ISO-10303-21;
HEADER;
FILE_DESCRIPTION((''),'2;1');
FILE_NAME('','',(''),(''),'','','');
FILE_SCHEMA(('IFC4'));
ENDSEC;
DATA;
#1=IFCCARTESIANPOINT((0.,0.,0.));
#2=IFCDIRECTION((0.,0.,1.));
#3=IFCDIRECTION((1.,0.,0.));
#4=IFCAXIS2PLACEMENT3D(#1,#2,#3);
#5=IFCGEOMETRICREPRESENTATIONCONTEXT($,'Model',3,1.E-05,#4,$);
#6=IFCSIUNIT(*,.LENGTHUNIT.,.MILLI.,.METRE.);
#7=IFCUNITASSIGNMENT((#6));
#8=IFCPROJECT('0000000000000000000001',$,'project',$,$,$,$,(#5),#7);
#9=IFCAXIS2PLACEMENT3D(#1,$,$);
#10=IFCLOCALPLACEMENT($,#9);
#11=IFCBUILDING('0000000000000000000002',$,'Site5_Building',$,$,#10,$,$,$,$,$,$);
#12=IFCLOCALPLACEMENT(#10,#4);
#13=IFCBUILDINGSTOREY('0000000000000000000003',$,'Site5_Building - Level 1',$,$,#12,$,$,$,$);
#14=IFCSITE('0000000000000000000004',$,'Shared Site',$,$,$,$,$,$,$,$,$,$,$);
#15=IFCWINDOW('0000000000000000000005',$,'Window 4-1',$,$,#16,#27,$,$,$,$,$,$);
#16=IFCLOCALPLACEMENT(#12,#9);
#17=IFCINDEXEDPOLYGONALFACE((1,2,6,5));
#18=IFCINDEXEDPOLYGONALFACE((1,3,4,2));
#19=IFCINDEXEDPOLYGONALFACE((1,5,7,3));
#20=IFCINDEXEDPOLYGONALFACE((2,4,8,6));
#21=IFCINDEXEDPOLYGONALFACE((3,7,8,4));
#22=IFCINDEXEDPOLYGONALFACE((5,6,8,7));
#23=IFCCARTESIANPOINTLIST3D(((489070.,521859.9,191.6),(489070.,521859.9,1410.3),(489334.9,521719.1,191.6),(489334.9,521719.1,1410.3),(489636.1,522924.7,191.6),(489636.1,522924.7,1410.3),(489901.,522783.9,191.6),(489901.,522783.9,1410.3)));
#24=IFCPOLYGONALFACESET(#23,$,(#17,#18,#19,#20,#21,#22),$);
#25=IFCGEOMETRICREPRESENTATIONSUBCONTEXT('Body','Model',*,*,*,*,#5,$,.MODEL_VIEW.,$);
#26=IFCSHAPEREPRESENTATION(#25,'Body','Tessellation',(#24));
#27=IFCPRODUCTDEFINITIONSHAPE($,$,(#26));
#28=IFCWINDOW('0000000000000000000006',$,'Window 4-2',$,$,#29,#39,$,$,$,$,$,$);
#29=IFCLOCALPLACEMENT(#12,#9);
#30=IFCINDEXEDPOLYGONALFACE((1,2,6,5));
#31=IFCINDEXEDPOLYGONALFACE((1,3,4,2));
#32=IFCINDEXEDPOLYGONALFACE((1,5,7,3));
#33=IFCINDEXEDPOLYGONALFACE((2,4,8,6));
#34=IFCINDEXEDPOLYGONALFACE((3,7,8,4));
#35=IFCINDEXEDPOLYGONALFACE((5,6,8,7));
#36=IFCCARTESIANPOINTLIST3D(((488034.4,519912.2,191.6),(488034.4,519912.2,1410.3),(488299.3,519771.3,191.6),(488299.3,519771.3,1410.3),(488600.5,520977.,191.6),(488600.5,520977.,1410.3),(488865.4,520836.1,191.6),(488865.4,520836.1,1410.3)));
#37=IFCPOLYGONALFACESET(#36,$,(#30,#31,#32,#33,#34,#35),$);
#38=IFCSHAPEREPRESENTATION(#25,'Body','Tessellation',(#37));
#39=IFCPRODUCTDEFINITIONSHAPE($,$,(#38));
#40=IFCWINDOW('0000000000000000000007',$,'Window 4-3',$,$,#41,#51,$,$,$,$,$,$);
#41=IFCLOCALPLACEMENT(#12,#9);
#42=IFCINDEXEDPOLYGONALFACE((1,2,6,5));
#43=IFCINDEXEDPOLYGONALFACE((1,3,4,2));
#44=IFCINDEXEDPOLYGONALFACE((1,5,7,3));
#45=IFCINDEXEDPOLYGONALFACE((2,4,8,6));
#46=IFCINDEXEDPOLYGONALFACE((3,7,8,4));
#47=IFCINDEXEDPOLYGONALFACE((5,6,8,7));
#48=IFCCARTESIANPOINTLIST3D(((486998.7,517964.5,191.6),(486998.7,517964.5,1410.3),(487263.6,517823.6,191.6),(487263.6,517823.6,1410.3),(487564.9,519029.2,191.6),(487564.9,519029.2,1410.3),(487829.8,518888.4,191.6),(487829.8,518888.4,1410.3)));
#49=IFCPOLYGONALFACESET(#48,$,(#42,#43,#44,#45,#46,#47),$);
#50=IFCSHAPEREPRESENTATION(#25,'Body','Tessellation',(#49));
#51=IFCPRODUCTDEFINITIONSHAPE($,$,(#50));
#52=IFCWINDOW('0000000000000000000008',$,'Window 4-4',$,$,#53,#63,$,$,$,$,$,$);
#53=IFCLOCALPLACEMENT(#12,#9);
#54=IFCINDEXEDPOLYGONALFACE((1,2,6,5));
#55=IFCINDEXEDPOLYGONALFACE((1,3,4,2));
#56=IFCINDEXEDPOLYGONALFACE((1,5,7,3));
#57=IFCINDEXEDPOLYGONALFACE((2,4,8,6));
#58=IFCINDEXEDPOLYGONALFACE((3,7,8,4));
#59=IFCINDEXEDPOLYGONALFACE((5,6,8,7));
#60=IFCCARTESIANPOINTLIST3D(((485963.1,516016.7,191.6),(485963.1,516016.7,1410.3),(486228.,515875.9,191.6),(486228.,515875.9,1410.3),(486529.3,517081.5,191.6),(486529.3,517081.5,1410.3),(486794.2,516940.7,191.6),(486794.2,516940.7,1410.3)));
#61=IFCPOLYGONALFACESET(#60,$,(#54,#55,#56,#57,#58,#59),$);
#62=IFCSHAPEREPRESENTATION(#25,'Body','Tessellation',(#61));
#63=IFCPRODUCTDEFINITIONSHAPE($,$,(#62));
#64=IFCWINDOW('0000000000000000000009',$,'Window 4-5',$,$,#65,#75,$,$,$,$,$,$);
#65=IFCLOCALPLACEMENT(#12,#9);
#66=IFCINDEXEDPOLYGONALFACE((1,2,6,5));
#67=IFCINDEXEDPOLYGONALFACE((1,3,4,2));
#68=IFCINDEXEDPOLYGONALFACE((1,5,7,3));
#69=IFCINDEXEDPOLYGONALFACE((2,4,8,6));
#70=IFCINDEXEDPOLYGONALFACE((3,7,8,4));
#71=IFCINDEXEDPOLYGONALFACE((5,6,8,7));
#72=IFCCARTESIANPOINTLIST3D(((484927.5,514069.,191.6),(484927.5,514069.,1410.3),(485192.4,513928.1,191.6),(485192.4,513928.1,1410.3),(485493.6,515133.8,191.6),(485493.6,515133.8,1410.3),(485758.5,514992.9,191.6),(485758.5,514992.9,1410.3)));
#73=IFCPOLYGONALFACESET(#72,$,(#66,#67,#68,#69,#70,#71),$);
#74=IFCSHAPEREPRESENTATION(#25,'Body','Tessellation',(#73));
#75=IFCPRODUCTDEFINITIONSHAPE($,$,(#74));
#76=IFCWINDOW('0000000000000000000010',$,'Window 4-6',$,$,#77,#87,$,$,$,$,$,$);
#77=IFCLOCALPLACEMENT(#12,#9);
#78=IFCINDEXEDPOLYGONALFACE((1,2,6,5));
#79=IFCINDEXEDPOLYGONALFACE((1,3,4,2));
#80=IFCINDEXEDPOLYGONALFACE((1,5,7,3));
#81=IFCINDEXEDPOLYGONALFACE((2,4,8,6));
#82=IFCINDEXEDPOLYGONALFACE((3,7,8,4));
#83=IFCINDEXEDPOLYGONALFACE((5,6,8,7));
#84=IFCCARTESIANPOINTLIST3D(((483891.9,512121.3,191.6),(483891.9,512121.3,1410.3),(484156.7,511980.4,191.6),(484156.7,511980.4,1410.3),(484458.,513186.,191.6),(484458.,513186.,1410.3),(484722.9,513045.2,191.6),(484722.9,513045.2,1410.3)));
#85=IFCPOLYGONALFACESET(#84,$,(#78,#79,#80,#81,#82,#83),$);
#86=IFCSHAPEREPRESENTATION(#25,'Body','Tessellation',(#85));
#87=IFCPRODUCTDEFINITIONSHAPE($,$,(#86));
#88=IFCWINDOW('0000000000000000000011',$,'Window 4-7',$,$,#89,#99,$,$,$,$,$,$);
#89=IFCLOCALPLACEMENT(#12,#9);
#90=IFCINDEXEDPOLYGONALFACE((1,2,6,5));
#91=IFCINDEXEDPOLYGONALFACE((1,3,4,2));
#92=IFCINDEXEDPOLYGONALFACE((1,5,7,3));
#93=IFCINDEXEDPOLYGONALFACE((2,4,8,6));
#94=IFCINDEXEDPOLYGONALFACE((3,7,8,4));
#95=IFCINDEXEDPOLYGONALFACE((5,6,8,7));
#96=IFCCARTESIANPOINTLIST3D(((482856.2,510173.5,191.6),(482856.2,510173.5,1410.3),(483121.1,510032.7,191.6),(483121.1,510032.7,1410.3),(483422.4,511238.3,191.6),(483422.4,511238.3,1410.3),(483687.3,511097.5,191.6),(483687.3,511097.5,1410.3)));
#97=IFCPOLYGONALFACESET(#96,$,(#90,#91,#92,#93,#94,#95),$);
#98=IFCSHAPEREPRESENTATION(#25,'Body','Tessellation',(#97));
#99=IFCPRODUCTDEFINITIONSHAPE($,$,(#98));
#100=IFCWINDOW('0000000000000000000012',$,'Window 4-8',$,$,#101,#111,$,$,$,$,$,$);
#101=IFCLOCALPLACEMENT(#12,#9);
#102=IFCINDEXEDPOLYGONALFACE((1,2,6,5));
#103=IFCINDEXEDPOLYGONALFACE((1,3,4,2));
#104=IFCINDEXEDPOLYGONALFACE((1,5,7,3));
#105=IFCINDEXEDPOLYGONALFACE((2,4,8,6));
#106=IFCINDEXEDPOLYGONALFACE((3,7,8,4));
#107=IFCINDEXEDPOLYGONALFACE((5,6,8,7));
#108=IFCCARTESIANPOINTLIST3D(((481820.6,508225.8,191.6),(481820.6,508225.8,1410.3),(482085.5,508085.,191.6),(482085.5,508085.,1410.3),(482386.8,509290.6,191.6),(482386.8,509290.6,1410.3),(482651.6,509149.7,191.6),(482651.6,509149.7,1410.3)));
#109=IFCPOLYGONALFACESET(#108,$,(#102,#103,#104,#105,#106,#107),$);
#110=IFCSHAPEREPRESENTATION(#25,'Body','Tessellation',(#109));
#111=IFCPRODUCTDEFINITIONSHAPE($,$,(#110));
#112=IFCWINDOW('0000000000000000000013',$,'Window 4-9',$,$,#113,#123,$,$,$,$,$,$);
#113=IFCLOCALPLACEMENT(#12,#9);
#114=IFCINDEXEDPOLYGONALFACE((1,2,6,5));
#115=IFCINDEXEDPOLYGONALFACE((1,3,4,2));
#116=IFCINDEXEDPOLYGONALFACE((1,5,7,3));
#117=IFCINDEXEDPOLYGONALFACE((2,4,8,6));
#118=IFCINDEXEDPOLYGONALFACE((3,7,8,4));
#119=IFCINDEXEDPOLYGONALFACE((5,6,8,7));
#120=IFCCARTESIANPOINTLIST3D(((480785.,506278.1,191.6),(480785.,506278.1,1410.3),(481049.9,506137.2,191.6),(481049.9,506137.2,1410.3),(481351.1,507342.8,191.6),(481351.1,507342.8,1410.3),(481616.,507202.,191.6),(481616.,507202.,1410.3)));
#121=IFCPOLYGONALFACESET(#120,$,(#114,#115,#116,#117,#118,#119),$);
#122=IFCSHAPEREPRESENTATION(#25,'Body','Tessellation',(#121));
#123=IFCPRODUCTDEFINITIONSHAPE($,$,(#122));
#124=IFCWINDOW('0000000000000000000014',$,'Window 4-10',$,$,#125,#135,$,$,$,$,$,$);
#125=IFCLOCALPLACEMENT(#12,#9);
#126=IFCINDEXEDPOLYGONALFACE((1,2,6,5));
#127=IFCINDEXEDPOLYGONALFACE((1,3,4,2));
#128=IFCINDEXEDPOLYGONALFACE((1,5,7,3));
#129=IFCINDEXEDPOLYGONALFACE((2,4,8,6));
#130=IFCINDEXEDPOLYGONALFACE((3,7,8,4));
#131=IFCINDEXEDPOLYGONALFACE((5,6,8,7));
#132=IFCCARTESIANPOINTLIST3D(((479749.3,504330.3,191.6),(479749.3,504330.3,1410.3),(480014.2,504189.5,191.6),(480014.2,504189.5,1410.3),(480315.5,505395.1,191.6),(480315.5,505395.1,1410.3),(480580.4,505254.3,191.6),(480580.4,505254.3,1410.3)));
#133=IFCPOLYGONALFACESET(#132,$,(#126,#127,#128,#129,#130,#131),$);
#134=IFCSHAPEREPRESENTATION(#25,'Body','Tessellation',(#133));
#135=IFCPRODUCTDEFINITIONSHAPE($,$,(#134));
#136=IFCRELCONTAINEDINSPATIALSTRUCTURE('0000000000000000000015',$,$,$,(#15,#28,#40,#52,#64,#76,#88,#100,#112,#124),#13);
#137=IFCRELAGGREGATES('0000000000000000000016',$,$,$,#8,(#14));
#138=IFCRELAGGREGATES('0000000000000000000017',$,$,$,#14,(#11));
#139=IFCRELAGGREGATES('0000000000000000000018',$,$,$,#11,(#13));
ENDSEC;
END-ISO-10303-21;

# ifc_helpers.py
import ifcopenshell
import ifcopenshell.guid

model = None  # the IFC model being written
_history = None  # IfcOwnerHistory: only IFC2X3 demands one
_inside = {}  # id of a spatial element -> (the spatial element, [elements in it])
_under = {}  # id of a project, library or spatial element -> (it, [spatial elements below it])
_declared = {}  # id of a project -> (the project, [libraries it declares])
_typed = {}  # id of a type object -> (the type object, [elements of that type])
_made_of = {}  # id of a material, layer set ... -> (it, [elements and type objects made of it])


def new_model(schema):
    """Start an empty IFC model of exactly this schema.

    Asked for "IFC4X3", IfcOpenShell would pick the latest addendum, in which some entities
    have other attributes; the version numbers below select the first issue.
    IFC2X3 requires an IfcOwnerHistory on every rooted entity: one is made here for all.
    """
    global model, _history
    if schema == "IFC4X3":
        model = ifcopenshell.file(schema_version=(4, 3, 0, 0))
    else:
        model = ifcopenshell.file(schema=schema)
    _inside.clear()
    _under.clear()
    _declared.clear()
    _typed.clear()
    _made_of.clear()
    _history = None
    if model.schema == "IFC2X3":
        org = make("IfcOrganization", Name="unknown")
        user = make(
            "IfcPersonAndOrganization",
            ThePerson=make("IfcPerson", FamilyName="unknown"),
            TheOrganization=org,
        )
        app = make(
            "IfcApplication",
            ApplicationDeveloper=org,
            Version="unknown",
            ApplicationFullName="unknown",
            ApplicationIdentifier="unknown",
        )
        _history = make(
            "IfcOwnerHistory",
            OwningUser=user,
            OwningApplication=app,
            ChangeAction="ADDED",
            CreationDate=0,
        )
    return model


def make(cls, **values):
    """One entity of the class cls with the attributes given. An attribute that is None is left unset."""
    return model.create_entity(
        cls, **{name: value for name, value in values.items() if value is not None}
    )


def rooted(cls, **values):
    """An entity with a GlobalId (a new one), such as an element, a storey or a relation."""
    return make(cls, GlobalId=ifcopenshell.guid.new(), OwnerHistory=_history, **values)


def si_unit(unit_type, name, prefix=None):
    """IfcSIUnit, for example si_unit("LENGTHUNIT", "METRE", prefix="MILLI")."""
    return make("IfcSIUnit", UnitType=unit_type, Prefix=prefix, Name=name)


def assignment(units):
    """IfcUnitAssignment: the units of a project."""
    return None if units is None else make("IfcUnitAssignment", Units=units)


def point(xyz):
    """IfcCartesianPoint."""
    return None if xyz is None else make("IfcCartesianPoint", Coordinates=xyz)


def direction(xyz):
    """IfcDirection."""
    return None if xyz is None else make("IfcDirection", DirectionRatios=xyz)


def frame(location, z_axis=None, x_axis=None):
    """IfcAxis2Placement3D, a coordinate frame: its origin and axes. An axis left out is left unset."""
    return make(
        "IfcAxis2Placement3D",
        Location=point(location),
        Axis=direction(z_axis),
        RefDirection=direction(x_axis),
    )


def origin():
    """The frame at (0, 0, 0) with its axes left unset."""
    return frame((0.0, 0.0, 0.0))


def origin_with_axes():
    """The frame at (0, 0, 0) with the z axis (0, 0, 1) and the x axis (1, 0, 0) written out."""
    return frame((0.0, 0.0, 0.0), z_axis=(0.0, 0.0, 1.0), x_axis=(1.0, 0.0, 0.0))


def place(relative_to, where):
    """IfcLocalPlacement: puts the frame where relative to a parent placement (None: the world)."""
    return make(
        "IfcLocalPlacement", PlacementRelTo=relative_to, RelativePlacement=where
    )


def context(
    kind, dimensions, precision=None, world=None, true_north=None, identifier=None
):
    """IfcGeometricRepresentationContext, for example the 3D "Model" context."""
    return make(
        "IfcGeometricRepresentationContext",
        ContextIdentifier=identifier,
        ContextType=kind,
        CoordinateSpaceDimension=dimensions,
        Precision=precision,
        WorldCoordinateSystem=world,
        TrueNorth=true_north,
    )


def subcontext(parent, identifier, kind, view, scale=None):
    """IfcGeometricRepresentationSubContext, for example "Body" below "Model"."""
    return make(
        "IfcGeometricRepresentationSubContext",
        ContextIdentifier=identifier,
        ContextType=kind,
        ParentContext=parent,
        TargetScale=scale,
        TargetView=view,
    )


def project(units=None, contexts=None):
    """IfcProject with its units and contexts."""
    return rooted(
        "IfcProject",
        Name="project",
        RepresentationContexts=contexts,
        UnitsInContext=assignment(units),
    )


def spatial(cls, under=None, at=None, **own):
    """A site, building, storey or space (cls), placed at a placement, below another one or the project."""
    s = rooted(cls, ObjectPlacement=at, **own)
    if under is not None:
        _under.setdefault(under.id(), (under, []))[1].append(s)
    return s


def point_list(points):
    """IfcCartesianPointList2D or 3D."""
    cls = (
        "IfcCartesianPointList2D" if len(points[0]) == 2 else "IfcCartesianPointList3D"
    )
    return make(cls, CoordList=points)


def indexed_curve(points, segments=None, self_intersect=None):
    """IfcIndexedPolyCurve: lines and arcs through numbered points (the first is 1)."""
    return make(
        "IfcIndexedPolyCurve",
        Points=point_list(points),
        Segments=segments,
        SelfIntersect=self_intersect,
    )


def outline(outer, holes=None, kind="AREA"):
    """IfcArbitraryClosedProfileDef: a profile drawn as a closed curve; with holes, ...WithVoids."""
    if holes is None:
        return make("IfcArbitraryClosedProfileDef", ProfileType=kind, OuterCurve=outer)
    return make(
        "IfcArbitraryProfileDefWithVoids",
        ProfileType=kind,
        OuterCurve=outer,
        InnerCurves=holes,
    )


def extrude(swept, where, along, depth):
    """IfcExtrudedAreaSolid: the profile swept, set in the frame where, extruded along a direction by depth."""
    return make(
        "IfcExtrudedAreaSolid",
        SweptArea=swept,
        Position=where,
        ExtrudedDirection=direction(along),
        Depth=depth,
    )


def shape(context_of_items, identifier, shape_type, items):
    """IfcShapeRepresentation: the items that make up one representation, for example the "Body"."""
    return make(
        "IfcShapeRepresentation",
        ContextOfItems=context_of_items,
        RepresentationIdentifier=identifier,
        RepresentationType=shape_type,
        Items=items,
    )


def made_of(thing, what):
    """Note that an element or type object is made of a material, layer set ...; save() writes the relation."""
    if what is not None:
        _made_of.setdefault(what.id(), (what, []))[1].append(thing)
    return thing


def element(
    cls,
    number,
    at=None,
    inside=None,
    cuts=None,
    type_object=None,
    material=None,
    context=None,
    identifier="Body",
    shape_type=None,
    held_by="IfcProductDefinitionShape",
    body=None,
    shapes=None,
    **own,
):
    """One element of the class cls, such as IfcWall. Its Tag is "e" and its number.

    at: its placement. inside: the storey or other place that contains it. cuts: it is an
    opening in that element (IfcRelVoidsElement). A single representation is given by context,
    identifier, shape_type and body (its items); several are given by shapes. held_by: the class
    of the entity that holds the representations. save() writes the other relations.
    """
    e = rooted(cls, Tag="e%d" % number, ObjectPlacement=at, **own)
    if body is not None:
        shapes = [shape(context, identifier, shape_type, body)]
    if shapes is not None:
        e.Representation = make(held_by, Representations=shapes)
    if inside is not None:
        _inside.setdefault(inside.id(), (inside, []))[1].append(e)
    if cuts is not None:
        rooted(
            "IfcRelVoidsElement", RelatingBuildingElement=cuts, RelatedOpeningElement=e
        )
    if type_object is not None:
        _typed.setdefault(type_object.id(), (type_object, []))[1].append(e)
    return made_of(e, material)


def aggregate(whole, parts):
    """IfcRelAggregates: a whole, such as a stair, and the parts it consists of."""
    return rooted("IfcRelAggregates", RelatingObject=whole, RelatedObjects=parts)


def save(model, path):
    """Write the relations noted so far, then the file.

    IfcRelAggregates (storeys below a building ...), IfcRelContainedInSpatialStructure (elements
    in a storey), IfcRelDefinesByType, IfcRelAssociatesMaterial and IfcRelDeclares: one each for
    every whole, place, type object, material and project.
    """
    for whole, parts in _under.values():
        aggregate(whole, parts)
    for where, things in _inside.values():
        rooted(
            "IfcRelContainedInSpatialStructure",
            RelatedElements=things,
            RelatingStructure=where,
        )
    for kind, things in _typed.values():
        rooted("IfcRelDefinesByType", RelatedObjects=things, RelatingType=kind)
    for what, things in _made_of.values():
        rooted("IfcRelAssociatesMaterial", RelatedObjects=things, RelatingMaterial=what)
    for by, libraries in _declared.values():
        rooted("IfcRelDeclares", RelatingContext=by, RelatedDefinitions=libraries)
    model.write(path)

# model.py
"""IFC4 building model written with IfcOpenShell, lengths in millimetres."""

from ifc_helpers import new_model, si_unit, frame, origin, origin_with_axes, place, context, subcontext, project, spatial, indexed_curve, outline, extrude, element, save


model = new_model("IFC4")

# Units and contexts
model_context = context("Model", 3, precision=1e-05, world=origin_with_axes())
body_context = subcontext(model_context, "Body", "Model", "MODEL_VIEW")
ifc_project = project(units=[si_unit("LENGTHUNIT", "METRE", prefix="MILLI")], contexts=[model_context])

# Site, building, storey
site = spatial("IfcSite", under=ifc_project, Name="Shared Site")
building_placement = place(None, origin())
building = spatial("IfcBuilding", under=site, at=building_placement, Name="Site5_Building")
storey_placement = place(building_placement, origin_with_axes())
storey = spatial("IfcBuildingStorey", under=building, at=storey_placement, Name="Site5_Building - Level 1")

# Windows
for number, where, z_axis, x_axis, name in (
    (1, (489636.1, 522924.7, 191.6), (0.0, 0.0, 1.0), (-0.469472, -0.882948, 0.0), "Window 4-1"),
    (2, (488600.5, 520977.0, 191.6), (0.0, 0.0, 1.0), (-0.469472, -0.882948, 0.0), "Window 4-2"),
    (3, (487564.9, 519029.2, 191.6), (0.0, 0.0, 1.0), (-0.469472, -0.882948, 0.0), "Window 4-3"),
    (4, (486529.3, 517081.5, 191.6), (0.0, 0.0, 1.0), (-0.469472, -0.882948, 0.0), "Window 4-4"),
    (5, (485493.6, 515133.8, 191.6), (0.0, 0.0, 1.0), (-0.469472, -0.882948, 0.0), "Window 4-5"),
    (6, (484458.0, 513186.0, 191.6), (0.0, 0.0, 1.0), (-0.469472, -0.882948, 0.0), "Window 4-6"),
    (7, (483422.4, 511238.3, 191.6), (0.0, 0.0, 1.0), (-0.469472, -0.882948, 0.0), "Window 4-7"),
    (8, (482386.8, 509290.6, 191.6), (0.0, 0.0, 1.0), (-0.469472, -0.882948, 0.0), "Window 4-8"),
    (9, (481351.1, 507342.8, 191.6), (0.0, 0.0, 1.0), (-0.469472, -0.882948, 0.0), "Window 4-9"),
    (10, (480315.5, 505395.1, 191.6), (0.0, 0.0, 1.0), (-0.469472, -0.882948, 0.0), "Window 4-10"),
):
    element("IfcWindow", number, at=place(storey_placement, frame(where, z_axis=z_axis, x_axis=x_axis)), inside=storey, Name=name, context=body_context, shape_type="SweptSolid", body=[
        extrude(outline(indexed_curve([(0.0, 0.0), (0.0, 300.0), (1205.9, 300.0), (1205.9, 0.0), (0.0, 0.0)], self_intersect=False)), origin_with_axes(), (0.0, 0.0, 1.0), 1218.8),
    ])

save(model, "model.ifc")
